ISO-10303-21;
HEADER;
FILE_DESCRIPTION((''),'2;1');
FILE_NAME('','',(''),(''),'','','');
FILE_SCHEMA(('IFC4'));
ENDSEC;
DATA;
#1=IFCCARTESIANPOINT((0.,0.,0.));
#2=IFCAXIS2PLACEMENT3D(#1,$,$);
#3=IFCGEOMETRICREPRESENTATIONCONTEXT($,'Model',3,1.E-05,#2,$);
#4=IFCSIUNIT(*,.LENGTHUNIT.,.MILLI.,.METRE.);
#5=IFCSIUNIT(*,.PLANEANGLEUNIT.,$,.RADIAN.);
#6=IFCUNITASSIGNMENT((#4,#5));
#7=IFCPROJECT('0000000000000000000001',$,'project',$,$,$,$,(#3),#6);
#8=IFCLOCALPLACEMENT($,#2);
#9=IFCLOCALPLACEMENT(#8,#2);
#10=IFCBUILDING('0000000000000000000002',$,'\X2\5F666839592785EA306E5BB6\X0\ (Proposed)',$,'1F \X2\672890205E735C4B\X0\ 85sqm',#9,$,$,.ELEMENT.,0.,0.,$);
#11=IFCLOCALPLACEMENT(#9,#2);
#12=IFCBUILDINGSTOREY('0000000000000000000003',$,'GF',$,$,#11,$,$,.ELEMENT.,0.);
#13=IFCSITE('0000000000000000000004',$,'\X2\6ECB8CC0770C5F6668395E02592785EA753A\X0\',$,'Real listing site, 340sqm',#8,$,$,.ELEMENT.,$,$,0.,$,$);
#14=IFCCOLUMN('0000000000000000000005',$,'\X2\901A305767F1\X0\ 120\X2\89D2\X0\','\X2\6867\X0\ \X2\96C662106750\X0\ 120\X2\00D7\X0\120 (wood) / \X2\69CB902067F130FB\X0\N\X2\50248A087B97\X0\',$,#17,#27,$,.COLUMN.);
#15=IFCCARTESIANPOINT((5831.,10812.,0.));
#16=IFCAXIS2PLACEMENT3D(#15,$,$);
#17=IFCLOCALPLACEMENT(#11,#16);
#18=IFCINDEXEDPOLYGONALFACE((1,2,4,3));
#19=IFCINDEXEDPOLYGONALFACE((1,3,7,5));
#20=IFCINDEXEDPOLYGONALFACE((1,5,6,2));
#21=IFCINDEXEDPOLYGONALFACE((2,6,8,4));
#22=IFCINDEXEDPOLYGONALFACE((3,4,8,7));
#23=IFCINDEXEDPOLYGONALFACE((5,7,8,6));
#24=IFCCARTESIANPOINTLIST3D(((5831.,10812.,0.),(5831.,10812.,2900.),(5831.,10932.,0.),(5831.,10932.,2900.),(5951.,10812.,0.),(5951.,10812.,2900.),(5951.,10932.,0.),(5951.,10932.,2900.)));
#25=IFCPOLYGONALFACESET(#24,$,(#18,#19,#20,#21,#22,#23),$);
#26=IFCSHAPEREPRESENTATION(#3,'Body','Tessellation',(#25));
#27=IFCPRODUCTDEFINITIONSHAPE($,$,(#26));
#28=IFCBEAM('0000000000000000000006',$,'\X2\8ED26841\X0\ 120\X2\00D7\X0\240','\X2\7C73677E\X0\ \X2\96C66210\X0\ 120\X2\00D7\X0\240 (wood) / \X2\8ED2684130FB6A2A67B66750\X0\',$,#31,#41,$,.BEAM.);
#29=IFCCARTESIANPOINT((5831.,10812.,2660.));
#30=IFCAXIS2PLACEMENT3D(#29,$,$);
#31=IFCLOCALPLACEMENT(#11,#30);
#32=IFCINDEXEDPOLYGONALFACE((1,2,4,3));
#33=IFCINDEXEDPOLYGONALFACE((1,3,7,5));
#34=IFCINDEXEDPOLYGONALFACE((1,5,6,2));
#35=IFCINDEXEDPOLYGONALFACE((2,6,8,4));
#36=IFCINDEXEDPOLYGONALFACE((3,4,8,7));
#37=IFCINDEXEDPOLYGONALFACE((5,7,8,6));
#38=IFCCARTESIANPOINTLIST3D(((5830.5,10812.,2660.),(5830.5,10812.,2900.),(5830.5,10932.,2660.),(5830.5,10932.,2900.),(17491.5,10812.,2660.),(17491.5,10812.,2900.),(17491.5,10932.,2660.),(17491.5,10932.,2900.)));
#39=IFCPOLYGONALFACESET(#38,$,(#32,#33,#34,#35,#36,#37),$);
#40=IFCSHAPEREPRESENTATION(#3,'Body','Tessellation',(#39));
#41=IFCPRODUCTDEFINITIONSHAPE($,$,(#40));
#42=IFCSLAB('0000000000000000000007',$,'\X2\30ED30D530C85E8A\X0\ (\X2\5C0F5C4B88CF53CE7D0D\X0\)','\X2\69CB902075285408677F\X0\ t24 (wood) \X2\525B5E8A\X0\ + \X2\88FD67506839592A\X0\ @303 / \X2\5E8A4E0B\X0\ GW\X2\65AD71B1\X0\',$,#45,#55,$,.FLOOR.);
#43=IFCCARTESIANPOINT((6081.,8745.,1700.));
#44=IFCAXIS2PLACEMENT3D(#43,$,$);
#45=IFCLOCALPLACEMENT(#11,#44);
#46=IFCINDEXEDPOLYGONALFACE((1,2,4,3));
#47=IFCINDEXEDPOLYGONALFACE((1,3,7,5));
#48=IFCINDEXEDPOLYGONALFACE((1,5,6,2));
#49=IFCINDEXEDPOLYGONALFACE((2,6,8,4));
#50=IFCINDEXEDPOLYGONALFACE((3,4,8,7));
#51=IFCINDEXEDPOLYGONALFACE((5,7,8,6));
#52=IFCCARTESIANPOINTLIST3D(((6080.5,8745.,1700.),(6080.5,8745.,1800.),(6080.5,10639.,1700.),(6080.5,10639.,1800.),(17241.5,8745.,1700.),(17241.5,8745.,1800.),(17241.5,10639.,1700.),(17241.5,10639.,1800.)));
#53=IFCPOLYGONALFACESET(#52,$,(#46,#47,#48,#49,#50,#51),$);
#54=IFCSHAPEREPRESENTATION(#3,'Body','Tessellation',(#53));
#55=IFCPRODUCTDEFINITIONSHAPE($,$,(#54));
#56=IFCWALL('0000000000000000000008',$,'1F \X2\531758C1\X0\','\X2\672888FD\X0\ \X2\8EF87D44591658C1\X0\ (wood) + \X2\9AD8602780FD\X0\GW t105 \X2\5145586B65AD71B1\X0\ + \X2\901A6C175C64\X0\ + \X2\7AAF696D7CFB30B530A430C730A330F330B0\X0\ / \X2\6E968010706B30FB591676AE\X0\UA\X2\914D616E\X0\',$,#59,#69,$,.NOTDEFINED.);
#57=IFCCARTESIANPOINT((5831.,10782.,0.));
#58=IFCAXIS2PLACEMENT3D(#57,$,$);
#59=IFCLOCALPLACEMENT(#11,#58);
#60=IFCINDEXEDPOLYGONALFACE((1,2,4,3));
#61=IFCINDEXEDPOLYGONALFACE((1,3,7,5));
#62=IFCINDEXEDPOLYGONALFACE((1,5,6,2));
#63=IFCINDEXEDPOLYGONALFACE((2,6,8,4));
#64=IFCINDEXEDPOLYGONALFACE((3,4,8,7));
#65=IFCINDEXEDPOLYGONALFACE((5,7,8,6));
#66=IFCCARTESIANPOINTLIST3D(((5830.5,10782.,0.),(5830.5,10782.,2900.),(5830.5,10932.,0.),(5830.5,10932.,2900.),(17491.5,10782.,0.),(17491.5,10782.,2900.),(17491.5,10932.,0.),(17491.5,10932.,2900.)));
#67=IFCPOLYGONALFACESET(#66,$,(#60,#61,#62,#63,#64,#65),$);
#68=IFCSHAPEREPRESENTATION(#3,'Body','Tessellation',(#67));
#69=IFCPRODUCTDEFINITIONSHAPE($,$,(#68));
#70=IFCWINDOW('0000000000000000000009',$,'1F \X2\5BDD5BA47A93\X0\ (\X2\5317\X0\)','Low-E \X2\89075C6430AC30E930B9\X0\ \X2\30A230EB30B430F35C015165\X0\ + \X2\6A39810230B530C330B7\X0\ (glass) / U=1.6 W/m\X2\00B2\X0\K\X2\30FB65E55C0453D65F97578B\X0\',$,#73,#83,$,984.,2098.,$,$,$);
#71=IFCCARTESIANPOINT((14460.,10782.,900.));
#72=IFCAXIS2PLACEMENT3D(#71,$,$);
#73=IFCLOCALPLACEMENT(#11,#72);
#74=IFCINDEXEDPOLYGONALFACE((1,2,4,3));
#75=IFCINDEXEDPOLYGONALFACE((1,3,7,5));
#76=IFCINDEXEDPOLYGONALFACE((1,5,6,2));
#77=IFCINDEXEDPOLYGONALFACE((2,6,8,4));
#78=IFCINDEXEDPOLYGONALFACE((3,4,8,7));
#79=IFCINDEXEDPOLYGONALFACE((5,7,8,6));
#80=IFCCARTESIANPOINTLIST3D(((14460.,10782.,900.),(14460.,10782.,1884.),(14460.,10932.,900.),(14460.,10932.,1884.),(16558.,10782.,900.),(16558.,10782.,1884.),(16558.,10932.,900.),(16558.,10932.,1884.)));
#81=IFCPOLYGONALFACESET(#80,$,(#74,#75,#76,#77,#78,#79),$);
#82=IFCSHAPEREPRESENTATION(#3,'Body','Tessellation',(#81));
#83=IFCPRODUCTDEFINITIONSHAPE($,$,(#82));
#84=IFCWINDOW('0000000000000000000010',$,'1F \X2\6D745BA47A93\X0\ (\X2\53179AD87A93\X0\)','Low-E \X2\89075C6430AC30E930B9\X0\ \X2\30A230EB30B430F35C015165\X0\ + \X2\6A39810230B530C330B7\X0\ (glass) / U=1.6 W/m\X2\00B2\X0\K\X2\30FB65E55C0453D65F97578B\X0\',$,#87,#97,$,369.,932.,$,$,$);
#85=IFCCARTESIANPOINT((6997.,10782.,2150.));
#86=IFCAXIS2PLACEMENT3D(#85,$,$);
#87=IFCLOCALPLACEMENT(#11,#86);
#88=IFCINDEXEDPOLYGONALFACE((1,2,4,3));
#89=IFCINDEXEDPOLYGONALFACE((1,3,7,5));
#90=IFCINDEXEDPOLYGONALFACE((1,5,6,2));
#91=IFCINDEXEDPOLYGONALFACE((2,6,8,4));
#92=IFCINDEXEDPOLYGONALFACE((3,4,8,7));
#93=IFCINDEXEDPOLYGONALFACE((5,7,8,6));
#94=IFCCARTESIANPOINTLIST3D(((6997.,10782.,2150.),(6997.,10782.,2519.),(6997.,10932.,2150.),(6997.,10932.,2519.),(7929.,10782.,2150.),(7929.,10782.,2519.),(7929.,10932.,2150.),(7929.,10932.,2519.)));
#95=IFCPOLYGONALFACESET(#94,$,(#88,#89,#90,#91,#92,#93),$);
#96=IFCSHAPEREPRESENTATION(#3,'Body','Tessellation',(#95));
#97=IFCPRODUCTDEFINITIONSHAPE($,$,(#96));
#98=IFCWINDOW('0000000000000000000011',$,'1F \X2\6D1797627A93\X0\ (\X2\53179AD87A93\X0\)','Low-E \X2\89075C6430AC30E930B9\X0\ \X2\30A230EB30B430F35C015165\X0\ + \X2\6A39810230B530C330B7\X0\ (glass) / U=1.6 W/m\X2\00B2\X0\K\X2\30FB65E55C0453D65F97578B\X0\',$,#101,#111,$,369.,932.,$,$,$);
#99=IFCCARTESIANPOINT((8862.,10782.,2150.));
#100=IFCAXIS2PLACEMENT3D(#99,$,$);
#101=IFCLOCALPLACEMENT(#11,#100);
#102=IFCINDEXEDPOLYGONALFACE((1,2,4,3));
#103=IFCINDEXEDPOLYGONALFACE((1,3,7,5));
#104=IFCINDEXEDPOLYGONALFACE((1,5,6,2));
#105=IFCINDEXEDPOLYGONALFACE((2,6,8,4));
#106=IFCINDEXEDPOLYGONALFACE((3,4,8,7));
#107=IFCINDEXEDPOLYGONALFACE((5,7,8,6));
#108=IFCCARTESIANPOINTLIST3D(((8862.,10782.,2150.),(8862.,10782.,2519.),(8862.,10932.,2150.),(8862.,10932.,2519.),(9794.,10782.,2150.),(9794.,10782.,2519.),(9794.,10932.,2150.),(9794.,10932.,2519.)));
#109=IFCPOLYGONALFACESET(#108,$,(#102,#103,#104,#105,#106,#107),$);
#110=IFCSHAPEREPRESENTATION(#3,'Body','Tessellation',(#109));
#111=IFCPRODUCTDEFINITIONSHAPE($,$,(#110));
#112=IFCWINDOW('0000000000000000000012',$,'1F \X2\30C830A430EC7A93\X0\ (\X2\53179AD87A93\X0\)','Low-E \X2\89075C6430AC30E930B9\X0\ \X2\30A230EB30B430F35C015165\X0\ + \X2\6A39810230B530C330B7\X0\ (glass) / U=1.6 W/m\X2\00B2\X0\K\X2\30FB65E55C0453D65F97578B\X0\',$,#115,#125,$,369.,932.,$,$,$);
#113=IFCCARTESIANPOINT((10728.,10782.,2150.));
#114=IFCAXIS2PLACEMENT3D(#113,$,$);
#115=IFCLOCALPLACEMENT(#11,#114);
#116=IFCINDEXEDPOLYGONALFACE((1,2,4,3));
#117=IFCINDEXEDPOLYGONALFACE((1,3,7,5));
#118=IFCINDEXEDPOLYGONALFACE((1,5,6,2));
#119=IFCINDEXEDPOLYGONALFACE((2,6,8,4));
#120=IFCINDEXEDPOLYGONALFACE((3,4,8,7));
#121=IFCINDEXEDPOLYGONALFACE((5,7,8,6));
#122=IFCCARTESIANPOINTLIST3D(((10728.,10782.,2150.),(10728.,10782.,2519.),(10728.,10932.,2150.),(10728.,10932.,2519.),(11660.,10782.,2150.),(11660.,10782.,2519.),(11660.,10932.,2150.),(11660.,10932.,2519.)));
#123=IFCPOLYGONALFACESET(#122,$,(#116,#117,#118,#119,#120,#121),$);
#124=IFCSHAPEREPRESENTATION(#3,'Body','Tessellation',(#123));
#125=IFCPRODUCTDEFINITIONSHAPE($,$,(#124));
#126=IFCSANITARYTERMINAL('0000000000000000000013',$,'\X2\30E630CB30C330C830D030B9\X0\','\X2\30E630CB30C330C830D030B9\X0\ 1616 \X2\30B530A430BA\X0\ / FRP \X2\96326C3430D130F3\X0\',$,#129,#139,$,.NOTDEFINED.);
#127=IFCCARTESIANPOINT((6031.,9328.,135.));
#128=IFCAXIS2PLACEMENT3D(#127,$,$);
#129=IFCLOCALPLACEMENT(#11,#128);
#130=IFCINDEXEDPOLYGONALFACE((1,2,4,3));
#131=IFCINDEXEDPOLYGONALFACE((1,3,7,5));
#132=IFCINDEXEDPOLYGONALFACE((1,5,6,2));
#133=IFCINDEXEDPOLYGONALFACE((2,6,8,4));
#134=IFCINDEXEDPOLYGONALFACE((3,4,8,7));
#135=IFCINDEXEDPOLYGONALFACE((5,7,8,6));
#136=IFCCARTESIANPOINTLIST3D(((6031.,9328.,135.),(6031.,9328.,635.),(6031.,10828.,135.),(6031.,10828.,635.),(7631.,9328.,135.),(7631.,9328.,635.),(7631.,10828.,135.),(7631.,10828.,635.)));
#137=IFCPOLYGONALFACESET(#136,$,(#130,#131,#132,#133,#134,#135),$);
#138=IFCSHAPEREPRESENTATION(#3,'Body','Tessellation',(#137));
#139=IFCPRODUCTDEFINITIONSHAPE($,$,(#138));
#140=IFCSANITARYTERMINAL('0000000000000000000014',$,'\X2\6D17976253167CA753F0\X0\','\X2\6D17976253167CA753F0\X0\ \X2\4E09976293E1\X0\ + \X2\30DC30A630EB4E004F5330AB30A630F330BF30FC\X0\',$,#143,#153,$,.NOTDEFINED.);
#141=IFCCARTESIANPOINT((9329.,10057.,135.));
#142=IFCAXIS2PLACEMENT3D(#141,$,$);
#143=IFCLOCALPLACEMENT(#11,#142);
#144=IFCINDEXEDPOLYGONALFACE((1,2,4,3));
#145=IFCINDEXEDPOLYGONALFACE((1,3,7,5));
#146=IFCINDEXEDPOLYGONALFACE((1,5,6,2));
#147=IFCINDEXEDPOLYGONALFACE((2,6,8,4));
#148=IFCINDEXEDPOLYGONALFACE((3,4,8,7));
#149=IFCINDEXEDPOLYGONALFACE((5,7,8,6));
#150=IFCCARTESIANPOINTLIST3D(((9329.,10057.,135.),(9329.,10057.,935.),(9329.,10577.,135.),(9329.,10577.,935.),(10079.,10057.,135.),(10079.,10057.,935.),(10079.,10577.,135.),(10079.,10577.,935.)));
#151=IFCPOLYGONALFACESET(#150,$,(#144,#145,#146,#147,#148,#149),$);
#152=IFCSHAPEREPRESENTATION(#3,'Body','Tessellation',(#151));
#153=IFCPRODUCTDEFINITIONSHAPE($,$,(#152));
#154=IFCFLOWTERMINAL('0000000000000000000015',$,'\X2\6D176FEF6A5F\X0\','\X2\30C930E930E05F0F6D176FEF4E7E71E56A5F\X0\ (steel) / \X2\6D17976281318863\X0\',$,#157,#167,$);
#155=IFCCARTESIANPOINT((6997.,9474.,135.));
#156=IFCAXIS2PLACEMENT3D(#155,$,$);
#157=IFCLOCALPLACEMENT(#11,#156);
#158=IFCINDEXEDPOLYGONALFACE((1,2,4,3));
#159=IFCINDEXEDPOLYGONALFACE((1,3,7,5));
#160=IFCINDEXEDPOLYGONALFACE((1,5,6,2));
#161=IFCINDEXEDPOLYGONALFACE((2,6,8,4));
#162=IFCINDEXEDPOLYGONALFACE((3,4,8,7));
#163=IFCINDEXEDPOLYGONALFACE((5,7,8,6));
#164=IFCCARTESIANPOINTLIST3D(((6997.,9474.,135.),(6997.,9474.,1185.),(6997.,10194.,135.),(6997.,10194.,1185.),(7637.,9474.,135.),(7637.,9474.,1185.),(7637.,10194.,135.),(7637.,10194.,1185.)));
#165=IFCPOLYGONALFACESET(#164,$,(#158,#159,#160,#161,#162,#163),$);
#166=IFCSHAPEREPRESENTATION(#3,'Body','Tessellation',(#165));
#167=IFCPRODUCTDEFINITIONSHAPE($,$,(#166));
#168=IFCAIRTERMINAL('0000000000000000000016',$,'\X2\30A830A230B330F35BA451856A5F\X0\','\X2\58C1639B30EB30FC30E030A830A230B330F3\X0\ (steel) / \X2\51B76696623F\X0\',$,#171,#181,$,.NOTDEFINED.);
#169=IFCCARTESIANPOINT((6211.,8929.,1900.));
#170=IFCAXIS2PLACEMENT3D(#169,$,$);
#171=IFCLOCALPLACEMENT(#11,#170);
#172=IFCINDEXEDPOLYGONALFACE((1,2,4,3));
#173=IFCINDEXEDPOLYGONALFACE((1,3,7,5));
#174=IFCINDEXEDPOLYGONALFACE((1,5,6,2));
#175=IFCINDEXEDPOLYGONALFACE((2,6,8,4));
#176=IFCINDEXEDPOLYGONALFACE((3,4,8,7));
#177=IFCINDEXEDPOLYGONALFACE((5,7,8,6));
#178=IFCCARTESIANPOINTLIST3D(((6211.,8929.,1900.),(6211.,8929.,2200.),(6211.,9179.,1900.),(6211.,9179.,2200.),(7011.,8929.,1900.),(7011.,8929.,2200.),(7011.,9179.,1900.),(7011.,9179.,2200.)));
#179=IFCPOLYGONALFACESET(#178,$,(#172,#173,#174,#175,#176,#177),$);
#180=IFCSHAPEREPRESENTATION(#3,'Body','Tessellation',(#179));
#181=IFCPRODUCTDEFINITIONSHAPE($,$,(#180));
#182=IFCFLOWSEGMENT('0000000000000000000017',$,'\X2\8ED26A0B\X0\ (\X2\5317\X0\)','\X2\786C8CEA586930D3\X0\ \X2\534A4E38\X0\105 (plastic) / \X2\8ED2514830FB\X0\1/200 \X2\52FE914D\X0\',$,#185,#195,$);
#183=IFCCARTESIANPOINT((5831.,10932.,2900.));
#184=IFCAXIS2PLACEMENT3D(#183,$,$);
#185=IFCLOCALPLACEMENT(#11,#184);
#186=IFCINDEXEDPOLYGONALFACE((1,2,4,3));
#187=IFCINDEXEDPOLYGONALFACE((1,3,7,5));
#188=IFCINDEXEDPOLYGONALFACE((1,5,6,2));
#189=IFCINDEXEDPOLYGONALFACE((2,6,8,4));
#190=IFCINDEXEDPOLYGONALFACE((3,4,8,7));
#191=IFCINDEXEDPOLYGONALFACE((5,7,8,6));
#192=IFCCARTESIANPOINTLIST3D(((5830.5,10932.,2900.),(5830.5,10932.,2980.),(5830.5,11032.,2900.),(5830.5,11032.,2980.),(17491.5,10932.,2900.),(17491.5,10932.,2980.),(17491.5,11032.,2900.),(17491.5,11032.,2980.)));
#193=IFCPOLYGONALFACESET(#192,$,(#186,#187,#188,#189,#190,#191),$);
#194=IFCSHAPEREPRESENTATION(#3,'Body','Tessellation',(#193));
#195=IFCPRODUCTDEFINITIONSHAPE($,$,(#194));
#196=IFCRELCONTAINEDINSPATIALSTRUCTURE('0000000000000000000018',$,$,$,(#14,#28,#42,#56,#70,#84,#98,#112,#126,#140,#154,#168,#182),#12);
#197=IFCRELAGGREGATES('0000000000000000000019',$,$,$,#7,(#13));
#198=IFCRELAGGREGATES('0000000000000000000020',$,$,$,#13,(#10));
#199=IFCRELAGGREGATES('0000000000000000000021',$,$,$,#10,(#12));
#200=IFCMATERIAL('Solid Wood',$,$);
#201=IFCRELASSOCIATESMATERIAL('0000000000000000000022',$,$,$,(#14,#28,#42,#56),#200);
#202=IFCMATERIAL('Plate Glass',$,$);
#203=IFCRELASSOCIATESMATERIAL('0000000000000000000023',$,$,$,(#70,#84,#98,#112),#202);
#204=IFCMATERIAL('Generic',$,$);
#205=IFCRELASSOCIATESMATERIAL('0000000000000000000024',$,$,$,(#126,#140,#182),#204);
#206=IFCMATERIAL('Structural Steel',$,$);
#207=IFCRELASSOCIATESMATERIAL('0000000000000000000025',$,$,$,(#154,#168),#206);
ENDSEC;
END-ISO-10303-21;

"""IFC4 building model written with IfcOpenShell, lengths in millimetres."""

from ifc_helpers import new_model, si_unit, frame, frame_2d, origin, place, context, project, spatial, rectangle, extrude, material, element, fill, save


model = new_model("IFC4")

# Units and contexts
model_context = context("Model", 3, precision=1e-05, world=origin())
ifc_project = project(units=[si_unit("LENGTHUNIT", "METRE", prefix="MILLI"), si_unit("PLANEANGLEUNIT", "RADIAN")], contexts=[model_context])

# Site, building, storey
site_placement = place(None, origin())
site = spatial("IfcSite", under=ifc_project, at=site_placement, Name="滋賀県彦根市大藪町", ObjectType="Real listing site, 340sqm", CompositionType="ELEMENT", RefElevation=0.0)
building_placement = place(site_placement, origin())
building = spatial("IfcBuilding", under=site, at=building_placement, Name="彦根大藪の家 (Proposed)", ObjectType="1F 木造平屋 85sqm", CompositionType="ELEMENT", ElevationOfRefHeight=0.0, ElevationOfTerrain=0.0)
storey_placement = place(building_placement, origin())
storey = spatial("IfcBuildingStorey", under=building, at=storey_placement, Name="GF", CompositionType="ELEMENT", Elevation=0.0)

# Column
ifc_material_1 = material(Name="Solid Wood")
column_1_placement = place(storey_placement, frame((5831.0, 10812.0, 0.0)))
element("IfcColumn", 1, at=column_1_placement, inside=storey, material=ifc_material_1, Name="通し柱 120角", Description="桧 集成材 120×120 (wood) / 構造柱・N値計算", PredefinedType="COLUMN", context=model_context, shape_type="SweptSolid", body=[
    extrude(rectangle(XDim=120.0, YDim=120.0, at=frame_2d((60.0, 60.0))), frame((5831.0, 10812.0, 0.0)), (0.0, 0.0, 1.0), 2900.0),
])

# Beam
beam_1_placement = place(storey_placement, frame((5831.0, 10812.0, 2660.0)))
element("IfcBeam", 2, at=beam_1_placement, inside=storey, material=ifc_material_1, Name="軒桁 120×240", Description="米松 集成 120×240 (wood) / 軒桁・横架材", PredefinedType="BEAM", context=model_context, shape_type="SweptSolid", body=[
    extrude(rectangle(XDim=11661.0, YDim=120.0, at=frame_2d((5830.0, 60.0))), frame((5831.0, 10812.0, 2660.0)), (0.0, 0.0, 1.0), 240.0),
])

# Slab
slab_placement = place(storey_placement, frame((6081.0, 8745.0, 1700.0)))
element("IfcSlab", 3, at=slab_placement, inside=storey, material=ifc_material_1, Name="ロフト床 (小屋裏収納)", Description="構造用合板 t24 (wood) 剛床 + 製材根太 @303 / 床下 GW断熱", PredefinedType="FLOOR", context=model_context, shape_type="SweptSolid", body=[
    extrude(rectangle(XDim=11161.0, YDim=1894.0, at=frame_2d((5580.0, 947.0))), frame((6081.0, 8745.0, 1700.0)), (0.0, 0.0, 1.0), 100.0),
])

# Wall, openings, windows
wall_1_placement = place(storey_placement, frame((5831.0, 10782.0, 0.0)))
wall_1 = element("IfcWall", 4, at=wall_1_placement, inside=storey, material=ifc_material_1, Name="1F 北壁", Description="木製 軸組外壁 (wood) + 高性能GW t105 充填断熱 + 通気層 + 窯業系サイディング / 準耐火・外皮UA配慮", PredefinedType="NOTDEFINED", context=model_context, shape_type="SweptSolid", body=[
    extrude(rectangle(XDim=11661.0, YDim=150.0, at=frame_2d((5830.0, 75.0))), frame((5831.0, 10782.0, 0.0)), (0.0, 0.0, 1.0), 2900.0),
])
opening_1_placement = place(storey_placement, frame((14460.0, 10782.0, 900.0)))
opening_1 = element("IfcOpeningElement", 5, at=opening_1_placement, cuts=wall_1, PredefinedType="NOTDEFINED", context=model_context, shape_type="SweptSolid", body=[
    extrude(rectangle(XDim=2098.0, YDim=150.0, at=frame_2d((1049.0, 75.0))), frame((14460.0, 10782.0, 900.0)), (0.0, 0.0, 1.0), 984.0),
])
opening_2_placement = place(storey_placement, frame((6997.0, 10782.0, 2150.0)))
opening_2 = element("IfcOpeningElement", 6, at=opening_2_placement, cuts=wall_1, PredefinedType="NOTDEFINED", context=model_context, shape_type="SweptSolid", body=[
    extrude(rectangle(XDim=932.0, YDim=150.0, at=frame_2d((466.0, 75.0))), frame((6997.0, 10782.0, 2150.0)), (0.0, 0.0, 1.0), 369.0),
])
opening_3_placement = place(storey_placement, frame((8862.0, 10782.0, 2150.0)))
opening_3 = element("IfcOpeningElement", 7, at=opening_3_placement, cuts=wall_1, PredefinedType="NOTDEFINED", context=model_context, shape_type="SweptSolid", body=[
    extrude(rectangle(XDim=932.0, YDim=150.0, at=frame_2d((466.0, 75.0))), frame((8862.0, 10782.0, 2150.0)), (0.0, 0.0, 1.0), 369.0),
])
opening_4_placement = place(storey_placement, frame((10728.0, 10782.0, 2150.0)))
opening_4 = element("IfcOpeningElement", 8, at=opening_4_placement, cuts=wall_1, PredefinedType="NOTDEFINED", context=model_context, shape_type="SweptSolid", body=[
    extrude(rectangle(XDim=932.0, YDim=150.0, at=frame_2d((466.0, 75.0))), frame((10728.0, 10782.0, 2150.0)), (0.0, 0.0, 1.0), 369.0),
])
ifc_material_2 = material(Name="Plate Glass")
window_1_placement = place(storey_placement, frame((14460.0, 10782.0, 900.0)))
window_1 = element("IfcWindow", 9, at=window_1_placement, inside=storey, material=ifc_material_2, Name="1F 寝室窓 (北)", Description="Low-E 複層ガラス アルゴン封入 + 樹脂サッシ (glass) / U=1.6 W/m²K・日射取得型", OverallHeight=984.0, OverallWidth=2098.0, context=model_context, shape_type="SweptSolid", body=[
    extrude(rectangle(XDim=2098.0, YDim=150.0, at=frame_2d((1049.0, 75.0))), frame((14460.0, 10782.0, 900.0)), (0.0, 0.0, 1.0), 984.0),
])
fill(opening_1, window_1)
window_2_placement = place(storey_placement, frame((6997.0, 10782.0, 2150.0)))
window_2 = element("IfcWindow", 10, at=window_2_placement, inside=storey, material=ifc_material_2, Name="1F 浴室窓 (北高窓)", Description="Low-E 複層ガラス アルゴン封入 + 樹脂サッシ (glass) / U=1.6 W/m²K・日射取得型", OverallHeight=369.0, OverallWidth=932.0, context=model_context, shape_type="SweptSolid", body=[
    extrude(rectangle(XDim=932.0, YDim=150.0, at=frame_2d((466.0, 75.0))), frame((6997.0, 10782.0, 2150.0)), (0.0, 0.0, 1.0), 369.0),
])
fill(opening_2, window_2)
window_3_placement = place(storey_placement, frame((8862.0, 10782.0, 2150.0)))
window_3 = element("IfcWindow", 11, at=window_3_placement, inside=storey, material=ifc_material_2, Name="1F 洗面窓 (北高窓)", Description="Low-E 複層ガラス アルゴン封入 + 樹脂サッシ (glass) / U=1.6 W/m²K・日射取得型", OverallHeight=369.0, OverallWidth=932.0, context=model_context, shape_type="SweptSolid", body=[
    extrude(rectangle(XDim=932.0, YDim=150.0, at=frame_2d((466.0, 75.0))), frame((8862.0, 10782.0, 2150.0)), (0.0, 0.0, 1.0), 369.0),
])
fill(opening_3, window_3)
window_4_placement = place(storey_placement, frame((10728.0, 10782.0, 2150.0)))
window_4 = element("IfcWindow", 12, at=window_4_placement, inside=storey, material=ifc_material_2, Name="1F トイレ窓 (北高窓)", Description="Low-E 複層ガラス アルゴン封入 + 樹脂サッシ (glass) / U=1.6 W/m²K・日射取得型", OverallHeight=369.0, OverallWidth=932.0, context=model_context, shape_type="SweptSolid", body=[
    extrude(rectangle(XDim=932.0, YDim=150.0, at=frame_2d((466.0, 75.0))), frame((10728.0, 10782.0, 2150.0)), (0.0, 0.0, 1.0), 369.0),
])
fill(opening_4, window_4)

# Shared definitions
ifc_material_3 = material(Name="Generic")

# Sanitary terminals
sanitary_terminal_1_placement = place(storey_placement, frame((6031.0, 9328.0, 135.0)))
element("IfcSanitaryTerminal", 13, at=sanitary_terminal_1_placement, inside=storey, material=ifc_material_3, Name="ユニットバス", Description="ユニットバス 1616 サイズ / FRP 防水パン", PredefinedType="NOTDEFINED", context=model_context, shape_type="SweptSolid", body=[
    extrude(rectangle(XDim=1600.0, YDim=1500.0, at=frame_2d((800.0, 750.0))), frame((6031.0, 9328.0, 135.0)), (0.0, 0.0, 1.0), 500.0),
])
sanitary_terminal_2_placement = place(storey_placement, frame((9329.0, 10057.0, 135.0)))
element("IfcSanitaryTerminal", 14, at=sanitary_terminal_2_placement, inside=storey, material=ifc_material_3, Name="洗面化粧台", Description="洗面化粧台 三面鏡 + ボウル一体カウンター", PredefinedType="NOTDEFINED", context=model_context, shape_type="SweptSolid", body=[
    extrude(rectangle(XDim=750.0, YDim=520.0, at=frame_2d((375.0, 260.0))), frame((9329.0, 10057.0, 135.0)), (0.0, 0.0, 1.0), 800.0),
])

# Flow terminal
ifc_material_4 = material(Name="Structural Steel")
flow_terminal_placement = place(storey_placement, frame((6997.0, 9474.0, 135.0)))
element("IfcFlowTerminal", 15, at=flow_terminal_placement, inside=storey, material=ifc_material_4, Name="洗濯機", Description="ドラム式洗濯乾燥機 (steel) / 洗面脱衣", context=model_context, shape_type="SweptSolid", body=[
    extrude(rectangle(XDim=640.0, YDim=720.0, at=frame_2d((320.0, 360.0))), frame((6997.0, 9474.0, 135.0)), (0.0, 0.0, 1.0), 1050.0),
])

# Air terminal
air_terminal_placement = place(storey_placement, frame((6211.0, 8929.0, 1900.0)))
element("IfcAirTerminal", 16, at=air_terminal_placement, inside=storey, material=ifc_material_4, Name="エアコン室内機", Description="壁掛ルームエアコン (steel) / 冷暖房", PredefinedType="NOTDEFINED", context=model_context, shape_type="SweptSolid", body=[
    extrude(rectangle(XDim=800.0, YDim=250.0, at=frame_2d((400.0, 125.0))), frame((6211.0, 8929.0, 1900.0)), (0.0, 0.0, 1.0), 300.0),
])

# Flow segment
flow_segment_1_placement = place(storey_placement, frame((5831.0, 10932.0, 2900.0)))
element("IfcFlowSegment", 17, at=flow_segment_1_placement, inside=storey, material=ifc_material_3, Name="軒樋 (北)", Description="硬質塩ビ 半丸105 (plastic) / 軒先・1/200 勾配", context=model_context, shape_type="SweptSolid", body=[
    extrude(rectangle(XDim=11661.0, YDim=100.0, at=frame_2d((5830.0, 50.0))), frame((5831.0, 10932.0, 2900.0)), (0.0, 0.0, 1.0), 80.0),
])

save(model, "model.ifc")
